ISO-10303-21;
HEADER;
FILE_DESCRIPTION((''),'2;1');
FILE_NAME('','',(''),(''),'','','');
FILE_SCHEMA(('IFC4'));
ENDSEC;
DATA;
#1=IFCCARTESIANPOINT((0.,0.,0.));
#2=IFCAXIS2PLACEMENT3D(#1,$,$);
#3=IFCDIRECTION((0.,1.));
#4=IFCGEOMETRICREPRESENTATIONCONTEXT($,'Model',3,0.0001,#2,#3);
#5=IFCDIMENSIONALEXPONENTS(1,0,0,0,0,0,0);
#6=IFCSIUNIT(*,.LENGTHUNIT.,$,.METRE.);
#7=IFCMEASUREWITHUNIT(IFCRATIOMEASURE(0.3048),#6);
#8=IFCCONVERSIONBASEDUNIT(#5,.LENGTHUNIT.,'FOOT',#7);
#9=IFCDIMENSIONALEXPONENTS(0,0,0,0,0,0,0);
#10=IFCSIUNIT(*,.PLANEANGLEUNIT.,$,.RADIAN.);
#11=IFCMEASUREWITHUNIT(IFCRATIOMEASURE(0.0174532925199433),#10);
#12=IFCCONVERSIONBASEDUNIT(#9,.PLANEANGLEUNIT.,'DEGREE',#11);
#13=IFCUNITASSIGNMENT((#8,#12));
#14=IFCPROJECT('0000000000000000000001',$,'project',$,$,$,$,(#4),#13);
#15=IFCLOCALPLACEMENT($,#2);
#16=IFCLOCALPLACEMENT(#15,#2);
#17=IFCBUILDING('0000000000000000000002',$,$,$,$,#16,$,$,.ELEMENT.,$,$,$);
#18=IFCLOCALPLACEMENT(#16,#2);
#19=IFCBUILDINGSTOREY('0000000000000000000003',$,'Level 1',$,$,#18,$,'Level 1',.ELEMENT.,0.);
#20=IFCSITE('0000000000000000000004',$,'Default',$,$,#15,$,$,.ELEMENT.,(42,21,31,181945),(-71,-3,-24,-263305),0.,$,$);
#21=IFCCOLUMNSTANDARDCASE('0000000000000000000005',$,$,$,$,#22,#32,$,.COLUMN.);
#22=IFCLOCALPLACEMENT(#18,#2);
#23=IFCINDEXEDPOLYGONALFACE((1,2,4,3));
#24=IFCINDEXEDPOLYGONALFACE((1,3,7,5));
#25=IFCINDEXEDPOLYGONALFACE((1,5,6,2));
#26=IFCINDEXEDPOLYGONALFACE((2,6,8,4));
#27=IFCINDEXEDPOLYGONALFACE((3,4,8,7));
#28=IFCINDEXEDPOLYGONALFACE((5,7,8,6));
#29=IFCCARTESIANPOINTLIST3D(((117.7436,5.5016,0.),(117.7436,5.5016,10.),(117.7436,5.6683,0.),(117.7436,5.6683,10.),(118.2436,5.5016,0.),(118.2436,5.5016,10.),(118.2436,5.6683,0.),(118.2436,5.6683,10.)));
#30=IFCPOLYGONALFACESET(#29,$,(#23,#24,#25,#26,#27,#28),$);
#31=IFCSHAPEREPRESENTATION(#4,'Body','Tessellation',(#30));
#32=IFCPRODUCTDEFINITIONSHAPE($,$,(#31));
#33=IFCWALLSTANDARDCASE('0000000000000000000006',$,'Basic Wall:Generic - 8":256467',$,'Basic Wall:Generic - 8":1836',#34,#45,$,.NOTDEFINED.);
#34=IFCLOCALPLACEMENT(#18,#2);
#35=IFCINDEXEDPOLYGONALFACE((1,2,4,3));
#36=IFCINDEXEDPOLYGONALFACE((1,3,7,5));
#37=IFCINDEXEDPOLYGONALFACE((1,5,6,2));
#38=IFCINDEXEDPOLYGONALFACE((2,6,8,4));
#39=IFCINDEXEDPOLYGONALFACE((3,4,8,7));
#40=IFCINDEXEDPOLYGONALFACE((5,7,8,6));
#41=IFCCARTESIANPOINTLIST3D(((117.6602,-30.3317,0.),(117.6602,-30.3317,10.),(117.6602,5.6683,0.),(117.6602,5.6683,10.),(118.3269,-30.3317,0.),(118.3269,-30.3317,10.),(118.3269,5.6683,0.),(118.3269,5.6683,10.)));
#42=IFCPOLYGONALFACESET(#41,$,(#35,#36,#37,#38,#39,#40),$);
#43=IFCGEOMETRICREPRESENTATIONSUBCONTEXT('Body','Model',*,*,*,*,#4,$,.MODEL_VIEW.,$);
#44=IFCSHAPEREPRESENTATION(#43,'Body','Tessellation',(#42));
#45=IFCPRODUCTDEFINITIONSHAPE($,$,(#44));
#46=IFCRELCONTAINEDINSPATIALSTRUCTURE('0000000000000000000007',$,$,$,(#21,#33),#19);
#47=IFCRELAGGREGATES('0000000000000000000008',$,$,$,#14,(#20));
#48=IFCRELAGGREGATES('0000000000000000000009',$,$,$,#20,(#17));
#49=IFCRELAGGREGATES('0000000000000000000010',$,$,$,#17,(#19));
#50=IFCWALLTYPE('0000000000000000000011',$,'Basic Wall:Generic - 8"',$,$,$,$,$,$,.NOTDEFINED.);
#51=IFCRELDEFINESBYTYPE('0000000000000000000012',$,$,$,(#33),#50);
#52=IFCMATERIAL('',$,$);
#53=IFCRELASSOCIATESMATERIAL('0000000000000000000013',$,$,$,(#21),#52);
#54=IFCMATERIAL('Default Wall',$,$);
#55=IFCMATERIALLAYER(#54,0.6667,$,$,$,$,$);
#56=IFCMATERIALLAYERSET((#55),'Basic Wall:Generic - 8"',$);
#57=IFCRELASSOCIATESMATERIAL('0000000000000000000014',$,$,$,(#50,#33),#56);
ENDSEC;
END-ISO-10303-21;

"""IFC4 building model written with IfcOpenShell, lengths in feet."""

from ifc_helpers import new_model, entity, si_unit, converted_unit, direction, frame, frame_2d, origin, place, context, subcontext, project, spatial, rectangle, extrude, material, layer, layer_set, layer_usage, type_object, element, save


model = new_model("IFC4")

# Units and contexts
model_context = context("Model", 3, precision=0.0001, world=origin(), true_north=direction((0.0, 1.0)))
body_context = subcontext(model_context, "Body", "Model", "MODEL_VIEW")
ifc_project = project(units=[converted_unit("LENGTHUNIT", "FOOT", entity("IfcRatioMeasure", 0.3048), si_unit("LENGTHUNIT", "METRE"), dimensions=[1, 0, 0, 0, 0, 0, 0]), converted_unit("PLANEANGLEUNIT", "DEGREE", entity("IfcRatioMeasure", 0.0174532925199433), si_unit("PLANEANGLEUNIT", "RADIAN"), dimensions=[0, 0, 0, 0, 0, 0, 0])], contexts=[model_context])

# Site, building, storey
site_placement = place(None, origin())
site = spatial("IfcSite", under=ifc_project, at=site_placement, Name="Default", CompositionType="ELEMENT", RefLatitude=(42, 21, 31, 181945), RefLongitude=(-71, -3, -24, -263305), RefElevation=0.0)
building_placement = place(site_placement, origin())
building = spatial("IfcBuilding", under=site, at=building_placement, CompositionType="ELEMENT")
storey_placement = place(building_placement, origin())
storey = spatial("IfcBuildingStorey", under=building, at=storey_placement, Name="Level 1", LongName="Level 1", CompositionType="ELEMENT", Elevation=0.0)

# Column
ifc_material_1 = material(Name="")
wall_placement = place(storey_placement, frame((117.9936, 5.6683, 0.0), z_axis=(0.0, 0.0, 1.0), x_axis=(0.0, -1.0, 0.0)))
for number, where, z_axis, x_axis in (
    (1, (0.0833, 0.0, 0.0), (0.0, 0.0, 1.0), (1.0, 0.0, 0.0)),
):
    element("IfcColumnStandardCase", number, at=place(wall_placement, frame(where, z_axis=z_axis, x_axis=x_axis)), inside=storey, material=ifc_material_1, PredefinedType="COLUMN", context=model_context, shape_type="SweptSolid", body=[
        extrude(rectangle(XDim=0.1667, YDim=0.5), origin(), (0.0, 0.0, 1.0), 10.0),
    ])

# Wall
ifc_material_2 = material(Name="Default Wall")
ifc_layer = layer(ifc_material_2, 0.6667)
ifc_layer_set = layer_set([ifc_layer], Name="Basic Wall:Generic - 8\"")
ifc_layer_usage = layer_usage(ifc_layer_set, "AXIS2", "NEGATIVE", 0.3333)
wall_type = type_object("IfcWallType", Name="Basic Wall:Generic - 8\"", PredefinedType="NOTDEFINED", material=ifc_layer_set)
element("IfcWallStandardCase", 2, at=wall_placement, inside=storey, type_object=wall_type, material=ifc_layer_usage, Name="Basic Wall:Generic - 8\":256467", ObjectType="Basic Wall:Generic - 8\":1836", PredefinedType="NOTDEFINED", context=body_context, shape_type="SweptSolid", body=[
    extrude(rectangle(XDim=36.0, YDim=0.6667, at=frame_2d((18.0, 0.0), x_axis=(-1.0, 0.0))), origin(), (0.0, 0.0, 1.0), 10.0),
])

save(model, "model.ifc")
